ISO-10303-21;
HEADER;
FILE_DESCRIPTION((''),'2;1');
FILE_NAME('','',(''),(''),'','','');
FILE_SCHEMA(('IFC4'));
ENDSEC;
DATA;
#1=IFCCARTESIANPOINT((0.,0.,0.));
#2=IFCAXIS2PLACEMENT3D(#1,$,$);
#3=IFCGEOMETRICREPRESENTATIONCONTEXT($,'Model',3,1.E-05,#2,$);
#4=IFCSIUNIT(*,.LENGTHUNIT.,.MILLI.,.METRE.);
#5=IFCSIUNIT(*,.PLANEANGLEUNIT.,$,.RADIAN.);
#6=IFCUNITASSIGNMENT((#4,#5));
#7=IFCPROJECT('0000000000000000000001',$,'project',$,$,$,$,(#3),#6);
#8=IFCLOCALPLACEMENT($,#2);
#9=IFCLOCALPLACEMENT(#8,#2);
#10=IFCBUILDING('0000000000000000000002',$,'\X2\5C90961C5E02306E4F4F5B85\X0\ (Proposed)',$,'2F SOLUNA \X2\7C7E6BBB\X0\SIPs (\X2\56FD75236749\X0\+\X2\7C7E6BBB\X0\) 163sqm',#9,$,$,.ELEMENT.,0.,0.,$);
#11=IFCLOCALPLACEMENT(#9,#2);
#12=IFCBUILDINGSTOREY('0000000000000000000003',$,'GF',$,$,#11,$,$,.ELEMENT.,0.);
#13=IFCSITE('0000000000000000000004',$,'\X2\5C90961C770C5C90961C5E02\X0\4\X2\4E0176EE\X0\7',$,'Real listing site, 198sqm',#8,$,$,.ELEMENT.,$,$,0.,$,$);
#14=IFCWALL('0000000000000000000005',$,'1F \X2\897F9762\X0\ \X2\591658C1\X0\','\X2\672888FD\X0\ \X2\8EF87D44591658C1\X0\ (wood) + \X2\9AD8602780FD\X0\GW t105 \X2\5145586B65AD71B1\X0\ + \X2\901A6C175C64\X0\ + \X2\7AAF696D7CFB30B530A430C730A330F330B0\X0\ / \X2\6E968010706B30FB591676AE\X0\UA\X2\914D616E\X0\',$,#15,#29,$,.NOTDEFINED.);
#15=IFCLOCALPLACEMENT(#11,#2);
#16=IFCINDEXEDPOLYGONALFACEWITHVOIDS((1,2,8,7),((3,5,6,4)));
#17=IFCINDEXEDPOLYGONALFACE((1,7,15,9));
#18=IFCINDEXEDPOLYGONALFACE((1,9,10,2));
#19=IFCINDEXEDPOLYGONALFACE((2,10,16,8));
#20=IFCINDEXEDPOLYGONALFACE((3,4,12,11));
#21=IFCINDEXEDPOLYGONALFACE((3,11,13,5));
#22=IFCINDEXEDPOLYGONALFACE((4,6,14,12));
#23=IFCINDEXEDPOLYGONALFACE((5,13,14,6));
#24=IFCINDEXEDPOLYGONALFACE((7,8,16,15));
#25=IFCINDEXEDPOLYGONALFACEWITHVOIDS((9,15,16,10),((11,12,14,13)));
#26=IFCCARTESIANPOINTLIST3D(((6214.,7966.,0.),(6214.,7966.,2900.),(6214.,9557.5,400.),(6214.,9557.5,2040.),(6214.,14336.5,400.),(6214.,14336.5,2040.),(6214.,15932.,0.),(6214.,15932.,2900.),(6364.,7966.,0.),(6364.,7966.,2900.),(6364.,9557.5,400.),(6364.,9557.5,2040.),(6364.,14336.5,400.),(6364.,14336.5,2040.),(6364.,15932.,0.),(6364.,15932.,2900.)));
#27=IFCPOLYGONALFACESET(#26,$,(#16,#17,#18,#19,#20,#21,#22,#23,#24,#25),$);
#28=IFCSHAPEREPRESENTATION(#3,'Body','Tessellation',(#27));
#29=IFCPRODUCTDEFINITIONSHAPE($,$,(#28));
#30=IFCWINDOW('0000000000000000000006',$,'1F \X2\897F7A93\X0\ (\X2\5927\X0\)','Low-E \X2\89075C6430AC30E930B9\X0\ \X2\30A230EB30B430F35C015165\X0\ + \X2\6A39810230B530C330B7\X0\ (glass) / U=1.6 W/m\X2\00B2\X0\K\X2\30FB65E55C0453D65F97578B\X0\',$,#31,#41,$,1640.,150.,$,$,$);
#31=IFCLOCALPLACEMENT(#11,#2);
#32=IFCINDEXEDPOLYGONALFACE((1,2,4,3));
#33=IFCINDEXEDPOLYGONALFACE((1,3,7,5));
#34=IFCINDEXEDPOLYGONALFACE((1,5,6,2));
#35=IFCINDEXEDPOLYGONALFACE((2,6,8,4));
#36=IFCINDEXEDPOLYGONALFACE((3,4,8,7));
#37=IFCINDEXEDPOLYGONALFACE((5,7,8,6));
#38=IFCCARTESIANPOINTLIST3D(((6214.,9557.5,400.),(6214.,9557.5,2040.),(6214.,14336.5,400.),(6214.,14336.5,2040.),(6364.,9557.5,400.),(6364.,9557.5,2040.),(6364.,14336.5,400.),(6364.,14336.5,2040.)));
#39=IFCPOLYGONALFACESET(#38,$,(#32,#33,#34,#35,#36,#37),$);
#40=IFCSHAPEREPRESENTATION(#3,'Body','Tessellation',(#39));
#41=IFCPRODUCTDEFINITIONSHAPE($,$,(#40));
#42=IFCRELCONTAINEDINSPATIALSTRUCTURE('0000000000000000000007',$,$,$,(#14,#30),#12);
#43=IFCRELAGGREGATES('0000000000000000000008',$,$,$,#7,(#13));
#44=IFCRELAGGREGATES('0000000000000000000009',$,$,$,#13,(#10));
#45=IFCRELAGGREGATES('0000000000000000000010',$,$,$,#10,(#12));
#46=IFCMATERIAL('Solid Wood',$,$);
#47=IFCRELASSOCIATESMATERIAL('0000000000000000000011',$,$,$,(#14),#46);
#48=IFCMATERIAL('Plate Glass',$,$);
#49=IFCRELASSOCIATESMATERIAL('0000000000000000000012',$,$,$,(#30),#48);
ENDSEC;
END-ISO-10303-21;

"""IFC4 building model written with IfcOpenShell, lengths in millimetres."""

from ifc_helpers import new_model, si_unit, frame, frame_2d, origin, place, context, project, spatial, rectangle, extrude, material, element, fill, save


model = new_model("IFC4")

# Units and contexts
model_context = context("Model", 3, precision=1e-05, world=origin())
ifc_project = project(units=[si_unit("LENGTHUNIT", "METRE", prefix="MILLI"), si_unit("PLANEANGLEUNIT", "RADIAN")], contexts=[model_context])

# Site, building, storey
site_placement = place(None, origin())
site = spatial("IfcSite", under=ifc_project, at=site_placement, Name="岐阜県岐阜市4丁目7", ObjectType="Real listing site, 198sqm", CompositionType="ELEMENT", RefElevation=0.0)
building_placement = place(site_placement, origin())
building = spatial("IfcBuilding", under=site, at=building_placement, Name="岐阜市の住宅 (Proposed)", ObjectType="2F SOLUNA 籾殻SIPs (国産杉+籾殻) 163sqm", CompositionType="ELEMENT", ElevationOfRefHeight=0.0, ElevationOfTerrain=0.0)
storey_placement = place(building_placement, origin())
storey = spatial("IfcBuildingStorey", under=building, at=storey_placement, Name="GF", CompositionType="ELEMENT", Elevation=0.0)

# Shared definitions
ifc_material_1 = material(Name="Solid Wood")

# Shared definitions
ifc_material_2 = material(Name="Plate Glass")

# Wall, opening, window
wall_1_placement = place(storey_placement, frame((3107.0, 3983.0, 0.0)))
wall_1 = element("IfcWall", 1, at=wall_1_placement, inside=storey, material=ifc_material_1, Name="1F 西面 外壁", Description="木製 軸組外壁 (wood) + 高性能GW t105 充填断熱 + 通気層 + 窯業系サイディング / 準耐火・外皮UA配慮", PredefinedType="NOTDEFINED", context=model_context, shape_type="SweptSolid", body=[
    extrude(rectangle(XDim=150.0, YDim=7966.0, at=frame_2d((75.0, 3983.0))), frame((3107.0, 3983.0, 0.0)), (0.0, 0.0, 1.0), 2900.0),
])
opening_1_placement = place(storey_placement, frame((3107.0, 4779.0, 200.0)))
opening_1 = element("IfcOpeningElement", 2, at=opening_1_placement, cuts=wall_1, PredefinedType="NOTDEFINED", context=model_context, shape_type="SweptSolid", body=[
    extrude(rectangle(XDim=150.0, YDim=4779.0, at=frame_2d((75.0, 2389.0))), frame((3107.0, 4779.0, 200.0)), (0.0, 0.0, 1.0), 1640.0),
])
window_1_placement = place(storey_placement, frame((3107.0, 4779.0, 200.0)))
window_1 = element("IfcWindow", 3, at=window_1_placement, inside=storey, material=ifc_material_2, Name="1F 西窓 (大)", Description="Low-E 複層ガラス アルゴン封入 + 樹脂サッシ (glass) / U=1.6 W/m²K・日射取得型", OverallHeight=1640.0, OverallWidth=150.0, context=model_context, shape_type="SweptSolid", body=[
    extrude(rectangle(XDim=150.0, YDim=4779.0, at=frame_2d((75.0, 2389.0))), frame((3107.0, 4779.0, 200.0)), (0.0, 0.0, 1.0), 1640.0),
])
fill(opening_1, window_1)

save(model, "model.ifc")
